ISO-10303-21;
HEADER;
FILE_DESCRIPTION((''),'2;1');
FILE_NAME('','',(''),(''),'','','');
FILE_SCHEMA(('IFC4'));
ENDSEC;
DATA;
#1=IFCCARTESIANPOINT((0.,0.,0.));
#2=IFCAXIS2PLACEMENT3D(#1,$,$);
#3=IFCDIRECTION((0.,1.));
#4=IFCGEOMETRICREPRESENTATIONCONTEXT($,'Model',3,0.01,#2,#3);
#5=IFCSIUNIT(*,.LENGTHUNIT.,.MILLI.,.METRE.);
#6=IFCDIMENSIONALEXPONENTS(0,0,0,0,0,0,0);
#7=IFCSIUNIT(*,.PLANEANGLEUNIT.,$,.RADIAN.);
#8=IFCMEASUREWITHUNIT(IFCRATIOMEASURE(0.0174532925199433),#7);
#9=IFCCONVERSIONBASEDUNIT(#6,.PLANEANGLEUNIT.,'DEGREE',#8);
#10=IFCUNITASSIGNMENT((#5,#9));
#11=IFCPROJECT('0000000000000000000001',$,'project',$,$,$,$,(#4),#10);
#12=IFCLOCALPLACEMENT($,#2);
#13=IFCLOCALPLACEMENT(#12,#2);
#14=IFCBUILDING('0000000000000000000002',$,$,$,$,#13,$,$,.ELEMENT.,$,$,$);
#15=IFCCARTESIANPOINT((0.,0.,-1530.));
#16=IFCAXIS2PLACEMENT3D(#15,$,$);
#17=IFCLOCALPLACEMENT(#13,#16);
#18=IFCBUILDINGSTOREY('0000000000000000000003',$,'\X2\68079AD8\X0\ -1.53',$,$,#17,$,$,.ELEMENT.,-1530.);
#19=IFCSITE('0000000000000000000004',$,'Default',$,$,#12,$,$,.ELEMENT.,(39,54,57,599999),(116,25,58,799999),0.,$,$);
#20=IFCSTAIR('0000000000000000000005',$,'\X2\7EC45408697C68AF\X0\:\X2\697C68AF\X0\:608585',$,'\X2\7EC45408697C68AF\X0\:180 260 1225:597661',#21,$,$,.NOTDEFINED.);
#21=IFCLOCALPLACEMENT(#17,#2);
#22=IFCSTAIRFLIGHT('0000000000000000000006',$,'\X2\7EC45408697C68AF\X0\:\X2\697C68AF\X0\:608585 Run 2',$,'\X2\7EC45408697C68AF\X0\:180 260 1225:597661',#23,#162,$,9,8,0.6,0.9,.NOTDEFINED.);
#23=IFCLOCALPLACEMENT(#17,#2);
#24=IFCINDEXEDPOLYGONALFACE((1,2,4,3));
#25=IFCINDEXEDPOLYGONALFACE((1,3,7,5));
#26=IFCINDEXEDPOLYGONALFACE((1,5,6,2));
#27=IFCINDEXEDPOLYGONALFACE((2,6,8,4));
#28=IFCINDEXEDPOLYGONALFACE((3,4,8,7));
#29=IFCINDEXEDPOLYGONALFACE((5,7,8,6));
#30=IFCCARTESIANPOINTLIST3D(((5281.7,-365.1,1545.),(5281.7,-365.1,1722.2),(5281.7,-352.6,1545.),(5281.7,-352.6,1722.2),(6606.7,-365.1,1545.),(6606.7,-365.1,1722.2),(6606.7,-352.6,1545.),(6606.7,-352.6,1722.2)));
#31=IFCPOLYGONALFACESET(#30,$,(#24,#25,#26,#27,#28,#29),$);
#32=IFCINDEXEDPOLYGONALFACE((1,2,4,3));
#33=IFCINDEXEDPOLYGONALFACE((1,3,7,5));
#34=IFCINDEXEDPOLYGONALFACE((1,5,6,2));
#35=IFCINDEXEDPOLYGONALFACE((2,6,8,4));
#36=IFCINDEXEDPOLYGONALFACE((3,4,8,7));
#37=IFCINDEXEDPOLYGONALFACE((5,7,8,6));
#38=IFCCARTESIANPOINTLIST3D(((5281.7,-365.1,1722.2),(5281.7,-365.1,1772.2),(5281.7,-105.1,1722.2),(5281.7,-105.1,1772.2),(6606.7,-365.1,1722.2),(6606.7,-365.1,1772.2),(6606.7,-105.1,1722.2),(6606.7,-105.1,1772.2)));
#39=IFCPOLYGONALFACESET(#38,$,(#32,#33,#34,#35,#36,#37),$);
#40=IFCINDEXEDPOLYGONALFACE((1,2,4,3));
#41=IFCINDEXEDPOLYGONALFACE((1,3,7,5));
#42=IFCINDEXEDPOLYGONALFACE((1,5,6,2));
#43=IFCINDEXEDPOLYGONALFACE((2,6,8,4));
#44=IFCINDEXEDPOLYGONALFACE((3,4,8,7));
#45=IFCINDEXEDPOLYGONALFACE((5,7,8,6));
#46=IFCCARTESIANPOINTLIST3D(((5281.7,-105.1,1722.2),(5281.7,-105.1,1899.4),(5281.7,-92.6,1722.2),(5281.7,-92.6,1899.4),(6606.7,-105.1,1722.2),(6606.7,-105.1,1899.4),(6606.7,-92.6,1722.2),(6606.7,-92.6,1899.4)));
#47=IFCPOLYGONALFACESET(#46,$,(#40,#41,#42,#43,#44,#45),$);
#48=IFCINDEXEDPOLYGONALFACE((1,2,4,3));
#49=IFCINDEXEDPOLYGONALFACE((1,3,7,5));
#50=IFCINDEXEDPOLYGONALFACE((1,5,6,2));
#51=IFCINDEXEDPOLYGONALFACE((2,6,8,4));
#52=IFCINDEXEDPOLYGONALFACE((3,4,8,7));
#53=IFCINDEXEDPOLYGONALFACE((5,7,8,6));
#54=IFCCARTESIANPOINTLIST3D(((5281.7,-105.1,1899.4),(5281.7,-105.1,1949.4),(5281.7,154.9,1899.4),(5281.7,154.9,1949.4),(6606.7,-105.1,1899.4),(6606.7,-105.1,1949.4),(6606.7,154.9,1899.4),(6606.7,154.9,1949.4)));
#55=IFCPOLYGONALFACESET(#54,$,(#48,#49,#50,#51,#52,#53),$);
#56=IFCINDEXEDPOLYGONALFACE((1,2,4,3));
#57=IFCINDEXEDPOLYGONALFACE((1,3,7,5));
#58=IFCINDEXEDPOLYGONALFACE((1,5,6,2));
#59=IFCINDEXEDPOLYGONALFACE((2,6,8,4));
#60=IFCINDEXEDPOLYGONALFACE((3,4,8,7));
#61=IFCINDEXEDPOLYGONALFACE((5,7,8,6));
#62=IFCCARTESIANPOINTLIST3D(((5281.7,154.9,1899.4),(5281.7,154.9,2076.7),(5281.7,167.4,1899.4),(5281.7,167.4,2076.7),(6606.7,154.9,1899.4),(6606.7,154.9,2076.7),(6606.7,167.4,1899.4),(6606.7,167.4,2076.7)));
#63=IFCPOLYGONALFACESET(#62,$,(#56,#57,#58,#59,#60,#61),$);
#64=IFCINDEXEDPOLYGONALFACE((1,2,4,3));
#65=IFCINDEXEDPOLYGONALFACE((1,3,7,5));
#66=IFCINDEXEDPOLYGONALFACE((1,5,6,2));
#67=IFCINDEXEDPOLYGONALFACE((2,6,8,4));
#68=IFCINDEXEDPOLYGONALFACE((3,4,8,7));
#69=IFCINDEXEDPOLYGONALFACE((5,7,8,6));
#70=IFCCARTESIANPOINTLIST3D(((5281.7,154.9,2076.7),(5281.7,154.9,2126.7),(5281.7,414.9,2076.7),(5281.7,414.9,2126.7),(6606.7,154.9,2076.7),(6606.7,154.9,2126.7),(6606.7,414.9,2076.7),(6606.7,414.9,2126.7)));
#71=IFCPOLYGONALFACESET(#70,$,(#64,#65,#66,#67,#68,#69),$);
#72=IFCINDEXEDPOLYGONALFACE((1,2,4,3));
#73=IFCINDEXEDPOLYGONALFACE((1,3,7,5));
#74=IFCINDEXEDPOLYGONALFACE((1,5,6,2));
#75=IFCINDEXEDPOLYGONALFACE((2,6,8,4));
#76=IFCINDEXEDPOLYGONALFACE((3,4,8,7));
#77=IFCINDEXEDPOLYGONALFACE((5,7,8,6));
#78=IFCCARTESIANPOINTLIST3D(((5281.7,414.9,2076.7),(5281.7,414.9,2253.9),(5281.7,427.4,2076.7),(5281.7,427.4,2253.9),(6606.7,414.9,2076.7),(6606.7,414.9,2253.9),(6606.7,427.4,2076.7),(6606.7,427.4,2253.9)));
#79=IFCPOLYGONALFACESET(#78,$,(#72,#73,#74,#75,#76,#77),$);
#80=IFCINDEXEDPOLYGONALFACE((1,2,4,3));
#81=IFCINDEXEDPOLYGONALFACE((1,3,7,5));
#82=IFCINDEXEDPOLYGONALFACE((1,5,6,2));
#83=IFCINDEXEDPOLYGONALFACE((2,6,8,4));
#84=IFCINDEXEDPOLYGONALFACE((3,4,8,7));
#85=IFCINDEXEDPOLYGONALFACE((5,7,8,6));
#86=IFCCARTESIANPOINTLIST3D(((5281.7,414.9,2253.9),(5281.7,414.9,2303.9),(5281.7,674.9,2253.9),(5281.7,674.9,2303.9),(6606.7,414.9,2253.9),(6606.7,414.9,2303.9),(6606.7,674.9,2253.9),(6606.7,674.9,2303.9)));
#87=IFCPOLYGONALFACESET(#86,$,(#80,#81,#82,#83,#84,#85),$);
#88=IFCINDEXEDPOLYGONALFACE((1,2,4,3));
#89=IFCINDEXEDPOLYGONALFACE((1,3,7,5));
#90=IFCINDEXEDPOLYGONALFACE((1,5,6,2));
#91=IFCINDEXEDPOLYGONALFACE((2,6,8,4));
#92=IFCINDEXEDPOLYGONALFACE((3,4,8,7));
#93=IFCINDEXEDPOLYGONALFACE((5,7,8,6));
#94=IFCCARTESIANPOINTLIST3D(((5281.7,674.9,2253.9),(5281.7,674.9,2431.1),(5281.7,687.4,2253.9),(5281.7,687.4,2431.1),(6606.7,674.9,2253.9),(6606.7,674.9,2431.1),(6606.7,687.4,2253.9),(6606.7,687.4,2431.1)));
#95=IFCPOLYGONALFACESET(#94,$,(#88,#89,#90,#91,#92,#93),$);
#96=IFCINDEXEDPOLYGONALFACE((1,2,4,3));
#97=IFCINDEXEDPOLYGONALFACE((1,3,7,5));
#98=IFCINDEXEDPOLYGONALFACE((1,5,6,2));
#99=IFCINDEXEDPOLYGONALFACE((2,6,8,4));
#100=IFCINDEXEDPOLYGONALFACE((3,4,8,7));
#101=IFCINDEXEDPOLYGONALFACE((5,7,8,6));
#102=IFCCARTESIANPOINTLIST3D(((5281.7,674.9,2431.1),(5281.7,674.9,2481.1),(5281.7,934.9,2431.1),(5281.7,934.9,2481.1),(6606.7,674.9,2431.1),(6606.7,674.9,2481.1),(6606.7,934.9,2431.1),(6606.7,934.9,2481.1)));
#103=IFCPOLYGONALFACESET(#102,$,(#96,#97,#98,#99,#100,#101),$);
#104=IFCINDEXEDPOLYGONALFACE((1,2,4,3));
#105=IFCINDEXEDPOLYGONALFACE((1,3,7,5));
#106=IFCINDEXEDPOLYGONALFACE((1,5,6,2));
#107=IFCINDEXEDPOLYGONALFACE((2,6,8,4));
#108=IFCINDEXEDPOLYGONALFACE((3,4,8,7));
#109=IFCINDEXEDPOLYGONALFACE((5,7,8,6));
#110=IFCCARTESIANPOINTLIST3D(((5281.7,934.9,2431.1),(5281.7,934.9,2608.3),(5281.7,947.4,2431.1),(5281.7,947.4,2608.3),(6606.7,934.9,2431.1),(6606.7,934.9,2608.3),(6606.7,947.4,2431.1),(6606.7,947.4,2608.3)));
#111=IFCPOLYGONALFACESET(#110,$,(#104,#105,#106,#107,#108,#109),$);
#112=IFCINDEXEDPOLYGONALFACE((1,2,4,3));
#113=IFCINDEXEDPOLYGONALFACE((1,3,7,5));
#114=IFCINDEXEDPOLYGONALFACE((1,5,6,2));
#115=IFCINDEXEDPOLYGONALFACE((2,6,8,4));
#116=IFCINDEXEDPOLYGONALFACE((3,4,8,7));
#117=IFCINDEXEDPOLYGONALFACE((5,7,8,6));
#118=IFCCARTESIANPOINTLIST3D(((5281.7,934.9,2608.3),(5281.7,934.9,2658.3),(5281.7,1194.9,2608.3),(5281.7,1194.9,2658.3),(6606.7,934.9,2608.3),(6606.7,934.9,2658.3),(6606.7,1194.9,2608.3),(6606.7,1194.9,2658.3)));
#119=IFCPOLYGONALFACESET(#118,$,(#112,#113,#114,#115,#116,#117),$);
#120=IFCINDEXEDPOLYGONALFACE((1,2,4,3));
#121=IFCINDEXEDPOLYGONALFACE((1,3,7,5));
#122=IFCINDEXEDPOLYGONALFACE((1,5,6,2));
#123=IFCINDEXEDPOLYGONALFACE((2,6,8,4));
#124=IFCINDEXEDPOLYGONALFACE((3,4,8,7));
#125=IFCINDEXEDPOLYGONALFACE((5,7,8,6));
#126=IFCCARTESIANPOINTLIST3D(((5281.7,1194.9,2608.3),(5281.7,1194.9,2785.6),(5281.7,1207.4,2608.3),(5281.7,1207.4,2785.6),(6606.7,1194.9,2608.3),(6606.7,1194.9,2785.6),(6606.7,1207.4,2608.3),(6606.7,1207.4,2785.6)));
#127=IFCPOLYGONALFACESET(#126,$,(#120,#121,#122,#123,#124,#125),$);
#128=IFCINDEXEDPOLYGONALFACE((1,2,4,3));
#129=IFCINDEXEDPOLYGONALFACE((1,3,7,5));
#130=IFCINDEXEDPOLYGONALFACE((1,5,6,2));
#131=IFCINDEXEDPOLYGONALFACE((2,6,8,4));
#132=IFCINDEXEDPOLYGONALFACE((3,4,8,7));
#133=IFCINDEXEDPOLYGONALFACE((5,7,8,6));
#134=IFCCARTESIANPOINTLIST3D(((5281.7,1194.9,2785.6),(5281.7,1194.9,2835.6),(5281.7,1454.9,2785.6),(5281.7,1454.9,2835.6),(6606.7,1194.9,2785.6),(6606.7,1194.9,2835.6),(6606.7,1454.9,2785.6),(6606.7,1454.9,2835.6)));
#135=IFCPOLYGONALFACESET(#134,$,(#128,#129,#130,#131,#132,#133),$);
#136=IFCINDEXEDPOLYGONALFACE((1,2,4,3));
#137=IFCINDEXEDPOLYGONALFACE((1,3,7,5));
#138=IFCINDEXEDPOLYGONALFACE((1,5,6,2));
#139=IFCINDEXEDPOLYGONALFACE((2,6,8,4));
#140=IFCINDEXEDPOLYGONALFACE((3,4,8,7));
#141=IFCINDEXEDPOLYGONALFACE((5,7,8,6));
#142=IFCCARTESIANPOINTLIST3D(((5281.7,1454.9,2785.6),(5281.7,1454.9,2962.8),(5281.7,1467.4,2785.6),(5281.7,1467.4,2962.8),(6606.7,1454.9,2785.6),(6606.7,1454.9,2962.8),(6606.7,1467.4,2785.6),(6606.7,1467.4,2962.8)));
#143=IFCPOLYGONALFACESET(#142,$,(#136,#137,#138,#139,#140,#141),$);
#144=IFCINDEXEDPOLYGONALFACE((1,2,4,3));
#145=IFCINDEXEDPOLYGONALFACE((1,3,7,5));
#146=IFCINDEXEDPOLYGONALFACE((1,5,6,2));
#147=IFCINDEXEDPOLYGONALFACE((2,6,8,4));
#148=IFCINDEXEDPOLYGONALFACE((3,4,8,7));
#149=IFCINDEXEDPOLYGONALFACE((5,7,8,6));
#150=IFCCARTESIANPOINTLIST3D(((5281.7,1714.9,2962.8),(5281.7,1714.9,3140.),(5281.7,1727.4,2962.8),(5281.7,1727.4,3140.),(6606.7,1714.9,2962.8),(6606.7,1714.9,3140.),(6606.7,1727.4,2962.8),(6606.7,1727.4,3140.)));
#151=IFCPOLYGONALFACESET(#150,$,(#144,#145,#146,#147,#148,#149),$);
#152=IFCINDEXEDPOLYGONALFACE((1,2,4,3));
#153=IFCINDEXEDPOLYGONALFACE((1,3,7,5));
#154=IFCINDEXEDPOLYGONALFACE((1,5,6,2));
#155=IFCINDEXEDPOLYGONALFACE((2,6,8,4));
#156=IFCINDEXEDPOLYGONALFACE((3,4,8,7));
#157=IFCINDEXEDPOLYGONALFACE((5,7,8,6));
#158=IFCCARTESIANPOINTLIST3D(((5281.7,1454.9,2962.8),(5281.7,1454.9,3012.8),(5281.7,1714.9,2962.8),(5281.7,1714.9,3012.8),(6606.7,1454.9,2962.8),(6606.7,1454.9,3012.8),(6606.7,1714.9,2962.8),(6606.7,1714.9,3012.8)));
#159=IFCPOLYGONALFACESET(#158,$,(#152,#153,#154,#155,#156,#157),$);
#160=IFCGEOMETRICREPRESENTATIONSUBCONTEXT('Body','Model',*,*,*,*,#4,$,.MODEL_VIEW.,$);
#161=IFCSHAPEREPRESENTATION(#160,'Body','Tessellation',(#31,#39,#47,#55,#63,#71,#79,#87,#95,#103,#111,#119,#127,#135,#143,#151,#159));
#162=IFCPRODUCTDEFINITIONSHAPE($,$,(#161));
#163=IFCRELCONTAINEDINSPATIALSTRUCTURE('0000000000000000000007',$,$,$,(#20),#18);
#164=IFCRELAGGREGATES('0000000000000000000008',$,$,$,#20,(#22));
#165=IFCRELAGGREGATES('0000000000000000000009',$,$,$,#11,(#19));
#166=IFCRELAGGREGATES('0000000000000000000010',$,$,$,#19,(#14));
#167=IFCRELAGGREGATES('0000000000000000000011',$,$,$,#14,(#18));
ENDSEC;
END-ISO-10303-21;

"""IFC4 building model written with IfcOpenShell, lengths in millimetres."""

from ifc_helpers import new_model, entity, si_unit, converted_unit, direction, frame, frame_2d, origin, origin_2d_with_axis, place, context, subcontext, project, spatial, rectangle, extrude, element, aggregate, save


model = new_model("IFC4")

# Units and contexts
model_context = context("Model", 3, precision=0.01, world=origin(), true_north=direction((0.0, 1.0)))
body_context = subcontext(model_context, "Body", "Model", "MODEL_VIEW")
ifc_project = project(units=[si_unit("LENGTHUNIT", "METRE", prefix="MILLI"), converted_unit("PLANEANGLEUNIT", "DEGREE", entity("IfcRatioMeasure", 0.0174532925199433), si_unit("PLANEANGLEUNIT", "RADIAN"), dimensions=[0, 0, 0, 0, 0, 0, 0])], contexts=[model_context])

# Site, building, storey
site_placement = place(None, origin())
site = spatial("IfcSite", under=ifc_project, at=site_placement, Name="Default", CompositionType="ELEMENT", RefLatitude=(39, 54, 57, 599999), RefLongitude=(116, 25, 58, 799999), RefElevation=0.0)
building_placement = place(site_placement, origin())
building = spatial("IfcBuilding", under=site, at=building_placement, CompositionType="ELEMENT")
storey_placement = place(building_placement, frame((0.0, 0.0, -1530.0)))
storey = spatial("IfcBuildingStorey", under=building, at=storey_placement, Name="标高 -1.53", CompositionType="ELEMENT", Elevation=-1530.0)

# Stair, stair flight
stair_placement = place(storey_placement, origin())
stair = element("IfcStair", 1, at=stair_placement, inside=storey, Name="组合楼梯:楼梯:608585", ObjectType="组合楼梯:180 260 1225:597661", PredefinedType="NOTDEFINED")
stair_flight_1_placement = place(stair_placement, frame((5281.7, -365.1, 0.0)))
stair_flight_1 = element("IfcStairFlight", 2, at=stair_flight_1_placement, Name="组合楼梯:楼梯:608585 Run 2", ObjectType="组合楼梯:180 260 1225:597661", NumberOfRisers=9, NumberOfTreads=8, PredefinedType="NOTDEFINED", RiserHeight=0.6, TreadLength=0.9, context=body_context, shape_type="SweptSolid", body=[
    extrude(rectangle(XDim=1325.0, YDim=12.5, at=origin_2d_with_axis()), frame((662.5, 6.2, 1545.0), z_axis=(0.0, 0.0, 1.0), x_axis=(-1.0, 0.0, 0.0)), (0.0, 0.0, 1.0), 177.2),
    extrude(rectangle(XDim=260.0, YDim=1325.0, at=frame_2d((0.0, 0.0), x_axis=(1.0, 0.0))), frame((662.5, 130.0, 1722.2), z_axis=(0.0, 0.0, 1.0), x_axis=(0.0, -1.0, 0.0)), (0.0, 0.0, 1.0), 50.0),
    extrude(rectangle(XDim=1325.0, YDim=12.5, at=origin_2d_with_axis()), frame((662.5, 266.2, 1722.2), z_axis=(0.0, 0.0, 1.0), x_axis=(-1.0, 0.0, 0.0)), (0.0, 0.0, 1.0), 177.2),
    extrude(rectangle(XDim=260.0, YDim=1325.0, at=frame_2d((0.0, 0.0), x_axis=(1.0, 0.0))), frame((662.5, 390.0, 1899.4), z_axis=(0.0, 0.0, 1.0), x_axis=(0.0, -1.0, 0.0)), (0.0, 0.0, 1.0), 50.0),
    extrude(rectangle(XDim=1325.0, YDim=12.5, at=origin_2d_with_axis()), frame((662.5, 526.2, 1899.4), z_axis=(0.0, 0.0, 1.0), x_axis=(-1.0, 0.0, 0.0)), (0.0, 0.0, 1.0), 177.2),
    extrude(rectangle(XDim=260.0, YDim=1325.0, at=frame_2d((0.0, 0.0), x_axis=(1.0, 0.0))), frame((662.5, 650.0, 2076.7), z_axis=(0.0, 0.0, 1.0), x_axis=(0.0, -1.0, 0.0)), (0.0, 0.0, 1.0), 50.0),
    extrude(rectangle(XDim=1325.0, YDim=12.5, at=frame_2d((0.0, 0.0), x_axis=(1.0, 0.0))), frame((662.5, 786.2, 2076.7), z_axis=(0.0, 0.0, 1.0), x_axis=(-1.0, 0.0, 0.0)), (0.0, 0.0, 1.0), 177.2),
    extrude(rectangle(XDim=260.0, YDim=1325.0, at=frame_2d((0.0, 0.0), x_axis=(1.0, 0.0))), frame((662.5, 910.0, 2253.9), z_axis=(0.0, 0.0, 1.0), x_axis=(0.0, -1.0, 0.0)), (0.0, 0.0, 1.0), 50.0),
    extrude(rectangle(XDim=1325.0, YDim=12.5, at=frame_2d((0.0, 0.0), x_axis=(1.0, 0.0))), frame((662.5, 1046.2, 2253.9), z_axis=(0.0, 0.0, 1.0), x_axis=(-1.0, 0.0, 0.0)), (0.0, 0.0, 1.0), 177.2),
    extrude(rectangle(XDim=260.0, YDim=1325.0, at=frame_2d((0.0, 0.0), x_axis=(1.0, 0.0))), frame((662.5, 1170.0, 2431.1), z_axis=(0.0, 0.0, 1.0), x_axis=(0.0, -1.0, 0.0)), (0.0, 0.0, 1.0), 50.0),
    extrude(rectangle(XDim=1325.0, YDim=12.5, at=frame_2d((0.0, 0.0), x_axis=(1.0, 0.0))), frame((662.5, 1306.2, 2431.1), z_axis=(0.0, 0.0, 1.0), x_axis=(-1.0, 0.0, 0.0)), (0.0, 0.0, 1.0), 177.2),
    extrude(rectangle(XDim=260.0, YDim=1325.0, at=frame_2d((0.0, 0.0), x_axis=(1.0, 0.0))), frame((662.5, 1430.0, 2608.3), z_axis=(0.0, 0.0, 1.0), x_axis=(0.0, -1.0, 0.0)), (0.0, 0.0, 1.0), 50.0),
    extrude(rectangle(XDim=1325.0, YDim=12.5, at=frame_2d((0.0, 0.0), x_axis=(1.0, 0.0))), frame((662.5, 1566.2, 2608.3), z_axis=(0.0, 0.0, 1.0), x_axis=(-1.0, 0.0, 0.0)), (0.0, 0.0, 1.0), 177.2),
    extrude(rectangle(XDim=260.0, YDim=1325.0, at=frame_2d((0.0, 0.0), x_axis=(1.0, 0.0))), frame((662.5, 1690.0, 2785.6), z_axis=(0.0, 0.0, 1.0), x_axis=(0.0, -1.0, 0.0)), (0.0, 0.0, 1.0), 50.0),
    extrude(rectangle(XDim=1325.0, YDim=12.5, at=frame_2d((0.0, 0.0), x_axis=(1.0, 0.0))), frame((662.5, 1826.2, 2785.6), z_axis=(0.0, 0.0, 1.0), x_axis=(-1.0, 0.0, 0.0)), (0.0, 0.0, 1.0), 177.2),
    extrude(rectangle(XDim=1325.0, YDim=12.5, at=frame_2d((0.0, 0.0), x_axis=(1.0, 0.0))), frame((662.5, 2086.2, 2962.8), z_axis=(0.0, 0.0, 1.0), x_axis=(-1.0, 0.0, 0.0)), (0.0, 0.0, 1.0), 177.2),
    extrude(rectangle(XDim=260.0, YDim=1325.0, at=frame_2d((0.0, 0.0), x_axis=(1.0, 0.0))), frame((662.5, 1950.0, 2962.8), z_axis=(0.0, 0.0, 1.0), x_axis=(0.0, -1.0, 0.0)), (0.0, 0.0, 1.0), 50.0),
])
aggregate(stair, [stair_flight_1])

save(model, "model.ifc")
